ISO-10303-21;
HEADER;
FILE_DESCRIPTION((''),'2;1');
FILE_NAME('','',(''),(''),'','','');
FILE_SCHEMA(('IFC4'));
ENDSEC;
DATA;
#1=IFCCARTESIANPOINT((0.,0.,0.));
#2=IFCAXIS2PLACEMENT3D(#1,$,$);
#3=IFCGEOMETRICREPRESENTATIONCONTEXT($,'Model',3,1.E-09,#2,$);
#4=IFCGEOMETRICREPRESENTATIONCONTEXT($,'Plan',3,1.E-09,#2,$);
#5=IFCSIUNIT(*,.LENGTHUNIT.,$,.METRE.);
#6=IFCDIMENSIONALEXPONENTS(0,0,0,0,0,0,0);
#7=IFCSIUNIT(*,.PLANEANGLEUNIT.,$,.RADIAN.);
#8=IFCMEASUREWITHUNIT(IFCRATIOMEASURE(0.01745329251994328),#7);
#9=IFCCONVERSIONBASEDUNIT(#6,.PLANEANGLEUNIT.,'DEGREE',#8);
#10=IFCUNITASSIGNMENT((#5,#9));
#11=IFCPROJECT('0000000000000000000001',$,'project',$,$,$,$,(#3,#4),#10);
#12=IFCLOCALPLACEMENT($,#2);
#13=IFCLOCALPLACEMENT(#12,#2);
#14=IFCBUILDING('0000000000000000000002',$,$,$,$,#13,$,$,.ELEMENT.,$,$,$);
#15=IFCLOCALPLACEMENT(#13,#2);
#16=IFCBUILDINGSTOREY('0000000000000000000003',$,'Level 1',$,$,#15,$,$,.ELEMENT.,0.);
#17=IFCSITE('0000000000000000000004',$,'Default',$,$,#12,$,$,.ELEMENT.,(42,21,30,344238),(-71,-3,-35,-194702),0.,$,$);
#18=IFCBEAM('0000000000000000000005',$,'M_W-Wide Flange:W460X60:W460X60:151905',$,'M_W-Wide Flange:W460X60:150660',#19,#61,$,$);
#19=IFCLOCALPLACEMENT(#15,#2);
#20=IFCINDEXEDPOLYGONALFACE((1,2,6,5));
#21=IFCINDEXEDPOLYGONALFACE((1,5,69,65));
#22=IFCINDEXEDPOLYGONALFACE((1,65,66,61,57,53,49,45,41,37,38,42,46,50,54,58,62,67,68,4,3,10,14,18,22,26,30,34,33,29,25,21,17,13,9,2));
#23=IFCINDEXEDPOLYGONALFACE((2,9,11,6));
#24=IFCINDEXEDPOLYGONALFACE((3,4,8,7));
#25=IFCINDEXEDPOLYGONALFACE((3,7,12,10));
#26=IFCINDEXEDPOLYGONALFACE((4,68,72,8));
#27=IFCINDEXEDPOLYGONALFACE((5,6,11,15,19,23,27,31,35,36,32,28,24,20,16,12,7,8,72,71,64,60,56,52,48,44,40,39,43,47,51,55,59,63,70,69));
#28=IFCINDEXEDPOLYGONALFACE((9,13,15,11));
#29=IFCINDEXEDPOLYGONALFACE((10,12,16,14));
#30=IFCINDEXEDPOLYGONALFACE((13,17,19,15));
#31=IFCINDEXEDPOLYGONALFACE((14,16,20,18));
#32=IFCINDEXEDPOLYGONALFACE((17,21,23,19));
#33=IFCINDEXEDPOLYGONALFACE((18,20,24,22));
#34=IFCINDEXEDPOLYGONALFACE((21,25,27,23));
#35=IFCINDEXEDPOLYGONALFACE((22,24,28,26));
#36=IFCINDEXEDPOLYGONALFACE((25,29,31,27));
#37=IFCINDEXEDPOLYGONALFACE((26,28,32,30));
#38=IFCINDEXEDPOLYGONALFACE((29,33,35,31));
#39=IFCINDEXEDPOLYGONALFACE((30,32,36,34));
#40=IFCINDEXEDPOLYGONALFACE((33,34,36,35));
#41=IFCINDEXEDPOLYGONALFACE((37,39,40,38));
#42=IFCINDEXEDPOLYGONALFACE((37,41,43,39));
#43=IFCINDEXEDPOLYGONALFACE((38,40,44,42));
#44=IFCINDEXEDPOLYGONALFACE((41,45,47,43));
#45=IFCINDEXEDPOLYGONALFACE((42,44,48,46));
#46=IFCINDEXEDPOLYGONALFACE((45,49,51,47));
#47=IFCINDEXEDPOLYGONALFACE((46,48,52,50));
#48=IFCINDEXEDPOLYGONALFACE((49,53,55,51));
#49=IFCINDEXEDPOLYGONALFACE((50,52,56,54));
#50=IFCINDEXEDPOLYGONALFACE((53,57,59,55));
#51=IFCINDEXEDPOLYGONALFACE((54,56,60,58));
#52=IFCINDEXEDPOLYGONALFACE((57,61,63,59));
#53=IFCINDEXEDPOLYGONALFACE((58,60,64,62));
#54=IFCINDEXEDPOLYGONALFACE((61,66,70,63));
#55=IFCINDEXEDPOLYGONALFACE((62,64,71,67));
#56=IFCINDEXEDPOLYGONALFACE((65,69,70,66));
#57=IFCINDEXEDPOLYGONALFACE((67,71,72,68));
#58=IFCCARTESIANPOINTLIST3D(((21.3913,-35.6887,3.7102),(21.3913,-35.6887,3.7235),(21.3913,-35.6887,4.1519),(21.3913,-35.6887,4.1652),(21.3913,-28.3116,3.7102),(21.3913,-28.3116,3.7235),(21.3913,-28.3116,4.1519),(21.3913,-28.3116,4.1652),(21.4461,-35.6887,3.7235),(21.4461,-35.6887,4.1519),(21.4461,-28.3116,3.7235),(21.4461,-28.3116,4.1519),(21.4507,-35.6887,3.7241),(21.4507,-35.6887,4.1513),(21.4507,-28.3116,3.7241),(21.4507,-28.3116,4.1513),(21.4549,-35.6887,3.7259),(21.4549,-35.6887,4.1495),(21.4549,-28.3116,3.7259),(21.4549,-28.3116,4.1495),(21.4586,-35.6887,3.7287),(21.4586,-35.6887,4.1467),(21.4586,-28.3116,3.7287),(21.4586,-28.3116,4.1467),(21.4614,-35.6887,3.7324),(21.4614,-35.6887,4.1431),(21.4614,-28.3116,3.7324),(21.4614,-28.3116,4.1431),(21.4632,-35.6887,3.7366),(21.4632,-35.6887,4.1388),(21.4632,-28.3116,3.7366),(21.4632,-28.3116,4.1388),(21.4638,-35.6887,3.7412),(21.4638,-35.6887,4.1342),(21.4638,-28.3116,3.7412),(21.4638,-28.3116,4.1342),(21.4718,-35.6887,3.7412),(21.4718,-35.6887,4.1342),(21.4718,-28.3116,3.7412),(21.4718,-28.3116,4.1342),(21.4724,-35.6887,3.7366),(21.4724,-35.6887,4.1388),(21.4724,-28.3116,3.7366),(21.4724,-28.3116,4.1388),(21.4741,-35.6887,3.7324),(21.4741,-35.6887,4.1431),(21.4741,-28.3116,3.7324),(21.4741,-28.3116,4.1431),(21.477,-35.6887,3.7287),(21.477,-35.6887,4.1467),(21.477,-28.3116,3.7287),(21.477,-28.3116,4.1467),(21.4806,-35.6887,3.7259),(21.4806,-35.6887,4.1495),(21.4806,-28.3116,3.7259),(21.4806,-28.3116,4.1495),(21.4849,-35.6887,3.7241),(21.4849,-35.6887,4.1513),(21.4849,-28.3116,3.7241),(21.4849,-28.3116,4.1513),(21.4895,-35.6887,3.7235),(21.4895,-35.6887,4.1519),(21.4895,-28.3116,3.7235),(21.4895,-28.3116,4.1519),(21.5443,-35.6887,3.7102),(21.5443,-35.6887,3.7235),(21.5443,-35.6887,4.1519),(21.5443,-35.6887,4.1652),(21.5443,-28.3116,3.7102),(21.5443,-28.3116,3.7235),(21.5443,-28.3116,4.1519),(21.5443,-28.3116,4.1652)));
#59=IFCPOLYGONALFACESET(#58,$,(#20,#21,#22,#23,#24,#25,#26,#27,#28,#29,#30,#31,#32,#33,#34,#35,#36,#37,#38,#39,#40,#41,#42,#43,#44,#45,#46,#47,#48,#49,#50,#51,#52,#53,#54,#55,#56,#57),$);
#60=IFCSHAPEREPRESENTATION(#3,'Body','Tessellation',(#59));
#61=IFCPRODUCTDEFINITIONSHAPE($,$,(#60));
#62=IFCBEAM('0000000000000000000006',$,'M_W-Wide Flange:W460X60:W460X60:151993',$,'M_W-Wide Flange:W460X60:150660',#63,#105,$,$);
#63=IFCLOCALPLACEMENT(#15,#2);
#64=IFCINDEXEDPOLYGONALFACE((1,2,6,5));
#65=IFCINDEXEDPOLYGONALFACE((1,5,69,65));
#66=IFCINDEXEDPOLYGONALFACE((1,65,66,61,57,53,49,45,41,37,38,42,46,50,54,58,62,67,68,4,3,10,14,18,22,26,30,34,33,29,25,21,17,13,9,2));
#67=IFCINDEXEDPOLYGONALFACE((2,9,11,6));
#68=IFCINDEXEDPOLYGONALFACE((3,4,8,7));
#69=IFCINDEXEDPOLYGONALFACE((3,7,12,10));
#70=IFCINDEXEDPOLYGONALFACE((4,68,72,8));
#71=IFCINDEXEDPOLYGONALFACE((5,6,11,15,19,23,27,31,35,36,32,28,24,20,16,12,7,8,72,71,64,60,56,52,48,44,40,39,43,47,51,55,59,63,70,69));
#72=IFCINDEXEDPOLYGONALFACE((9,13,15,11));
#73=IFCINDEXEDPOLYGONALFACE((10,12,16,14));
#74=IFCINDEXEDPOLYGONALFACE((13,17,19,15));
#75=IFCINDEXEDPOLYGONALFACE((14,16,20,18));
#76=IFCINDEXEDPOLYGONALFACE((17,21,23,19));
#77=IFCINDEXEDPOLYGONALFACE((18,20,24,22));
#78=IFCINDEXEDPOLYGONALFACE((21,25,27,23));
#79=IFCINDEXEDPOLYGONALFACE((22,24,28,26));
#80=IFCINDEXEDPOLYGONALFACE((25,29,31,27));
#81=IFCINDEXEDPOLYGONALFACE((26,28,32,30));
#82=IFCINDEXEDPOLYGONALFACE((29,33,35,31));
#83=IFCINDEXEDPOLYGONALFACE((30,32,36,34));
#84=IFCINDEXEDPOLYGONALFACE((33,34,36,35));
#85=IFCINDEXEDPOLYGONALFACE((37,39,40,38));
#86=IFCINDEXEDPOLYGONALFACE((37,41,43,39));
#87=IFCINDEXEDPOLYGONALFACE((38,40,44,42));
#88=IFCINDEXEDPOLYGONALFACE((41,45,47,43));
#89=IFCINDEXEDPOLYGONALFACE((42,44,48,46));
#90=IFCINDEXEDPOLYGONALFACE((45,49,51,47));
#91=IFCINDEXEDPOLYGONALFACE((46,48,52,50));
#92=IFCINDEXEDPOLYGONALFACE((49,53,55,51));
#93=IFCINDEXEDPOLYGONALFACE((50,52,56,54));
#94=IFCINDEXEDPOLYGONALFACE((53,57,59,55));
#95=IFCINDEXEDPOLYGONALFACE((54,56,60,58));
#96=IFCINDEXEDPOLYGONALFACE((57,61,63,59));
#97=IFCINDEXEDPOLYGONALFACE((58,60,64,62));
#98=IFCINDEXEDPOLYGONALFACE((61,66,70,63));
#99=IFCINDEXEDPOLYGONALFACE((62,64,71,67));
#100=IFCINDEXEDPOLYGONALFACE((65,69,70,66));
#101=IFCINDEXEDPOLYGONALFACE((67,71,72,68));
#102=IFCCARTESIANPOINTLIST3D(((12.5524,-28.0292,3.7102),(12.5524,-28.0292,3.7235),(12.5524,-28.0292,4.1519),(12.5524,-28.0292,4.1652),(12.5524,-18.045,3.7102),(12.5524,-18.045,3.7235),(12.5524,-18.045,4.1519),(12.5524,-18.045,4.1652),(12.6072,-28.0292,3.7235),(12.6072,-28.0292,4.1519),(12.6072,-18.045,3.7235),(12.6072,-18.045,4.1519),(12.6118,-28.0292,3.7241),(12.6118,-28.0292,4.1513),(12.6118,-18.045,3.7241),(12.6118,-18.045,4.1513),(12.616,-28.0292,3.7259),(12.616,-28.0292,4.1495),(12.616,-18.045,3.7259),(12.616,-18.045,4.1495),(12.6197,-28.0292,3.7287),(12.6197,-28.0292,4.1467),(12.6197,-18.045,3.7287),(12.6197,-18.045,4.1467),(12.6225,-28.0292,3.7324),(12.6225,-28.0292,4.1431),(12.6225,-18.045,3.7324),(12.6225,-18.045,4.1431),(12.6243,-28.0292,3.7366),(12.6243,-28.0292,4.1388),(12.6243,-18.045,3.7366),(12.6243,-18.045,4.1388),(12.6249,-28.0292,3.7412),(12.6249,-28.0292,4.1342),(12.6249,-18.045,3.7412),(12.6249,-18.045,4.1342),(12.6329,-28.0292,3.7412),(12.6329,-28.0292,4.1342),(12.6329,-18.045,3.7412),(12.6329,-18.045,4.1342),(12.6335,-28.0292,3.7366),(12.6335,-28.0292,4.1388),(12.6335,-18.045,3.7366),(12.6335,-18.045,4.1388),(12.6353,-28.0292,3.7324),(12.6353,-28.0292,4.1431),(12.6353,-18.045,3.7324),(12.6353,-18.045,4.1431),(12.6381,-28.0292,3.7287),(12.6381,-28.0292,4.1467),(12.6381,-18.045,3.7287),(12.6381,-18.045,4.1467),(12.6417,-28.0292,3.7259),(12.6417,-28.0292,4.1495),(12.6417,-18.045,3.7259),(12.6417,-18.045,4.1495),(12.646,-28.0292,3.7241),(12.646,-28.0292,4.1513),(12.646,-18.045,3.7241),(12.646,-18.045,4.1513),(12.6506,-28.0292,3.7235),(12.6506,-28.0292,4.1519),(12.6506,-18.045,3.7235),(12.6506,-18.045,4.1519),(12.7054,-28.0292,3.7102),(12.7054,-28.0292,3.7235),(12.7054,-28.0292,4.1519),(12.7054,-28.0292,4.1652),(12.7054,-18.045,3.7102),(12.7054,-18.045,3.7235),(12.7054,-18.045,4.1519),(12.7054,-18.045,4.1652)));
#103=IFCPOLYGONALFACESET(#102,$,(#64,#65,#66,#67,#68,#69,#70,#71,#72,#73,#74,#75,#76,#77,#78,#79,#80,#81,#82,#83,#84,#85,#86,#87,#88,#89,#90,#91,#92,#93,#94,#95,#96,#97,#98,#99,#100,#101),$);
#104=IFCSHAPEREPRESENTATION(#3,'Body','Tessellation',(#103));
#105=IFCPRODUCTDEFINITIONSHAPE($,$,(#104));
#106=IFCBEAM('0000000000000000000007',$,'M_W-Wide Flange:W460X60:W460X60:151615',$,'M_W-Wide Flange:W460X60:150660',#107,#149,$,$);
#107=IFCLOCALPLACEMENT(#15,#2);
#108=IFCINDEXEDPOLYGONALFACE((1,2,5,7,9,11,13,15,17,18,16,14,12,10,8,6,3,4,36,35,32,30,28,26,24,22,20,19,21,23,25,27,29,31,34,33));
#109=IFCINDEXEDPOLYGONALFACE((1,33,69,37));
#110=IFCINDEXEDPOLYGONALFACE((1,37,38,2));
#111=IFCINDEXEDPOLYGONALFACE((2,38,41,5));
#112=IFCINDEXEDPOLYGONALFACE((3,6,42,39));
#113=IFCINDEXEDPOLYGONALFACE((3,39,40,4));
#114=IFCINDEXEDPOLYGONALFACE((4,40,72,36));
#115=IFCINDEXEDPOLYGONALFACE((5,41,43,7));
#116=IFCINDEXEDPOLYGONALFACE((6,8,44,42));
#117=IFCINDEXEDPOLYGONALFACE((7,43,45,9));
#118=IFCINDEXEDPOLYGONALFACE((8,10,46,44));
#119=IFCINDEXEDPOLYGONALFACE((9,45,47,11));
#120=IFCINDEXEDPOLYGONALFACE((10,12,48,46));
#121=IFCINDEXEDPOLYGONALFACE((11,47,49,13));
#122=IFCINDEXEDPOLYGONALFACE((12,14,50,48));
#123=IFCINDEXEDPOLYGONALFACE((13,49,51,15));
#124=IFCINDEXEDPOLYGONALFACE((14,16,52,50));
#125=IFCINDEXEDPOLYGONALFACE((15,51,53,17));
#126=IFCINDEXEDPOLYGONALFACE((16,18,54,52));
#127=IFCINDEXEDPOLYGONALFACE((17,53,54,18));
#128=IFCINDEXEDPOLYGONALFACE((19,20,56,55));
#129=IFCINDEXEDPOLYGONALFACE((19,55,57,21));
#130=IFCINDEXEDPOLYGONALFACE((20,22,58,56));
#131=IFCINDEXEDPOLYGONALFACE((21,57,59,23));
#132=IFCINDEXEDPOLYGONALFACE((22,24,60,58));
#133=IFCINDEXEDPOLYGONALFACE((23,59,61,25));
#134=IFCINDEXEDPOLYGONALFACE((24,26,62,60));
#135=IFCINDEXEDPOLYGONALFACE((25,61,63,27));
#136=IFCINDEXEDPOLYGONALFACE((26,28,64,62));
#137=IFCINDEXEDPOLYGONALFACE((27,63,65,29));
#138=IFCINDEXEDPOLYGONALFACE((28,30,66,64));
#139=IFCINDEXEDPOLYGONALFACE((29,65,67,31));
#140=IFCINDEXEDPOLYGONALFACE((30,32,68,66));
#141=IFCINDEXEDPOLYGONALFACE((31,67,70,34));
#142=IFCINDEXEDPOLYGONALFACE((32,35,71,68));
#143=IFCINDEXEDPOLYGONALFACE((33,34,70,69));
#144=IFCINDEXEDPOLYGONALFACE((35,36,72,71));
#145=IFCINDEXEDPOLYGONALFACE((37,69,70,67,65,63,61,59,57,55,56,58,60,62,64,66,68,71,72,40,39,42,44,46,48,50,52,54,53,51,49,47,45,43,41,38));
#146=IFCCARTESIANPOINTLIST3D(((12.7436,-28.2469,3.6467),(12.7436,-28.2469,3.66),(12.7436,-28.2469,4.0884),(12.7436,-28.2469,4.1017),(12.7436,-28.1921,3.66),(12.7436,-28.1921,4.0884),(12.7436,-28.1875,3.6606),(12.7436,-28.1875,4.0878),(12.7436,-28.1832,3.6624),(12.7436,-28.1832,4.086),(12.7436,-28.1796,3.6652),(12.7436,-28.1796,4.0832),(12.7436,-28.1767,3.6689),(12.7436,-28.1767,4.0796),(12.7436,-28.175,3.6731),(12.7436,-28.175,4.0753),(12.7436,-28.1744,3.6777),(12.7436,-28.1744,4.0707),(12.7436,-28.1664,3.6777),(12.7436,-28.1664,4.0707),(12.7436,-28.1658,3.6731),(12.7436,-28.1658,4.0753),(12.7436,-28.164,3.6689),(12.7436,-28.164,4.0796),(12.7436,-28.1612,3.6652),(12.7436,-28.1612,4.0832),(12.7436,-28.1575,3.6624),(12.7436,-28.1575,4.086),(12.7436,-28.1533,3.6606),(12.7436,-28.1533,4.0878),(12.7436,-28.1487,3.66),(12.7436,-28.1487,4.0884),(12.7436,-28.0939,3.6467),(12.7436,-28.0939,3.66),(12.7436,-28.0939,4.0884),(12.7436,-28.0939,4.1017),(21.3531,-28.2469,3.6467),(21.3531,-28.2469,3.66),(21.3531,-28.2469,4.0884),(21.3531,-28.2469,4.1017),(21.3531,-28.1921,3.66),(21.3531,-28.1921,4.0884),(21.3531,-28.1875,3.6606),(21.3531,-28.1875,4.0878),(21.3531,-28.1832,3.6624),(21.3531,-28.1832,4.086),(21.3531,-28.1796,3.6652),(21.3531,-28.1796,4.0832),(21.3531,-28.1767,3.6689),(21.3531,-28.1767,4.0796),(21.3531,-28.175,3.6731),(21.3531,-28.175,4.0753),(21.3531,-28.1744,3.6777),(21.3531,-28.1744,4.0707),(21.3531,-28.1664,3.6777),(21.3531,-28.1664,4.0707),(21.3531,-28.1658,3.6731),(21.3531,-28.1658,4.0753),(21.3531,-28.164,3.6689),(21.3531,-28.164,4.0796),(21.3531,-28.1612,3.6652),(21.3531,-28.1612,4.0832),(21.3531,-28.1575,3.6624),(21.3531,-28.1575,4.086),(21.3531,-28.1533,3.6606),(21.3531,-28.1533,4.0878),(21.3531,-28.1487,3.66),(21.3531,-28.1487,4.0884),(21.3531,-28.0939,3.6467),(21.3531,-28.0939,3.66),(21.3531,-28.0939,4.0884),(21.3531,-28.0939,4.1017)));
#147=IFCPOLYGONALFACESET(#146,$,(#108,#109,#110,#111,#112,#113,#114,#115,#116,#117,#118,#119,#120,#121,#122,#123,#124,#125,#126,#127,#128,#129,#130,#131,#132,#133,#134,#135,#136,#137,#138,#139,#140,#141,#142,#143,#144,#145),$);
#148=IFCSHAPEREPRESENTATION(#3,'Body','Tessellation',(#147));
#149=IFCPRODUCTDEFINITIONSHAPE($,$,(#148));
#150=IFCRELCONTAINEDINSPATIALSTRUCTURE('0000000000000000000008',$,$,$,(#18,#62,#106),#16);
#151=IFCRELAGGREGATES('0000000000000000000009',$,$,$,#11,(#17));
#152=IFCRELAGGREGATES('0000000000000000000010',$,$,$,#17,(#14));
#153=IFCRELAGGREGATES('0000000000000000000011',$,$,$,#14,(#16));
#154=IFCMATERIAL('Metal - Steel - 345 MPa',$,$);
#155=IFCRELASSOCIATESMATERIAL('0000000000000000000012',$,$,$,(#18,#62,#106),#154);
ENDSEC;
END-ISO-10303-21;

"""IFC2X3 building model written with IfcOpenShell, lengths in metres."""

from ifc_helpers import new_model, entity, si_unit, converted_unit, frame, frame_2d, origin, place, context, project, spatial, polyline, circle_curve, parameter, trimmed, segment, composite_curve, outline, extrude, material, element, save


model = new_model("IFC2X3")

# Units and contexts
model_context = context("Model", 3, precision=1e-09, world=origin())
plan_context = context("Plan", 3, precision=1e-09, world=origin())
ifc_project = project(units=[si_unit("LENGTHUNIT", "METRE"), converted_unit("PLANEANGLEUNIT", "DEGREE", entity("IfcRatioMeasure", 0.01745329251994328), si_unit("PLANEANGLEUNIT", "RADIAN"), dimensions=[0, 0, 0, 0, 0, 0, 0])], contexts=[model_context, plan_context])

# Site, building, storey
site_placement = place(None, origin())
site = spatial("IfcSite", under=ifc_project, at=site_placement, Name="Default", CompositionType="ELEMENT", RefLatitude=(42, 21, 30, 344238), RefLongitude=(-71, -3, -35, -194702), RefElevation=0.0)
building_placement = place(site_placement, origin())
building = spatial("IfcBuilding", under=site, at=building_placement, CompositionType="ELEMENT")
storey_placement = place(building_placement, origin())
storey = spatial("IfcBuildingStorey", under=building, at=storey_placement, Name="Level 1", CompositionType="ELEMENT", Elevation=0.0)

# Beams
ifc_material_1 = material(Name="Metal - Steel - 345 MPa")
beam_1_placement = place(storey_placement, frame((21.4678, -35.8299, 4.2672)))
element("IfcBeam", 1, at=beam_1_placement, inside=storey, material=ifc_material_1, Name="M_W-Wide Flange:W460X60:W460X60:151905", ObjectType="M_W-Wide Flange:W460X60:150660", context=model_context, shape_type="SweptSolid", body=[
    extrude(outline(composite_curve([segment(polyline([(-0.0765, -0.2142), (-0.0765, -0.2275)]), True, "CONTINUOUS"), segment(polyline([(-0.0765, -0.2275), (0.0765, -0.2275)]), True, "CONTINUOUS"), segment(polyline([(0.0765, -0.2275), (0.0765, -0.2142)]), True, "CONTINUOUS"), segment(polyline([(0.0765, -0.2142), (0.0217, -0.2142)]), True, "CONTINUOUS"), segment(trimmed(circle_curve(frame_2d((0.0217, -0.1965), x_axis=(0.0, -1.0)), 0.0177), [parameter(270.0)], [parameter(360.0)], True, "PARAMETER"), False, "CONTINUOUS"), segment(polyline([(0.004, -0.1965), (0.004, 0.1965)]), True, "CONTINUOUS"), segment(trimmed(circle_curve(frame_2d((0.0217, 0.1965), x_axis=(-1.0, 0.0)), 0.0177), [parameter(270.0)], [parameter(360.0)], True, "PARAMETER"), False, "CONTINUOUS"), segment(polyline([(0.0217, 0.2142), (0.0765, 0.2142)]), True, "CONTINUOUS"), segment(polyline([(0.0765, 0.2142), (0.0765, 0.2275)]), True, "CONTINUOUS"), segment(polyline([(0.0765, 0.2275), (-0.0765, 0.2275)]), True, "CONTINUOUS"), segment(polyline([(-0.0765, 0.2275), (-0.0765, 0.2142)]), True, "CONTINUOUS"), segment(polyline([(-0.0765, 0.2142), (-0.0217, 0.2142)]), True, "CONTINUOUS"), segment(trimmed(circle_curve(frame_2d((-0.0217, 0.1965), x_axis=(0.0, 1.0)), 0.0177), [parameter(270.0)], [parameter(360.0)], True, "PARAMETER"), False, "CONTINUOUS"), segment(polyline([(-0.004, 0.1965), (-0.004, -0.1965)]), True, "CONTINUOUS"), segment(trimmed(circle_curve(frame_2d((-0.0217, -0.1965), x_axis=(1.0, 0.0)), 0.0177), [parameter(270.0)], [parameter(0.0)], True, "PARAMETER"), False, "CONTINUOUS"), segment(polyline([(-0.0217, -0.2142), (-0.0765, -0.2142)]), True, "CONTINUOUS")], self_intersect=False)), frame((0.0, 0.1412, -0.3295), z_axis=(0.0, -1.0, 0.0), x_axis=(1.0, 0.0, 0.0)), (0.0, 0.0, -1.0), 7.3771),
])
beam_2_placement = place(storey_placement, frame((12.6289, -17.9038, 4.2672), z_axis=(0.0, 0.0, 1.0), x_axis=(-1.0, 0.0, 0.0)))
element("IfcBeam", 2, at=beam_2_placement, inside=storey, material=ifc_material_1, Name="M_W-Wide Flange:W460X60:W460X60:151993", ObjectType="M_W-Wide Flange:W460X60:150660", context=model_context, shape_type="SweptSolid", body=[
    extrude(outline(composite_curve([segment(polyline([(0.2142, -0.0765), (0.2275, -0.0765)]), True, "CONTINUOUS"), segment(polyline([(0.2275, -0.0765), (0.2275, 0.0765)]), True, "CONTINUOUS"), segment(polyline([(0.2275, 0.0765), (0.2142, 0.0765)]), True, "CONTINUOUS"), segment(polyline([(0.2142, 0.0765), (0.2142, 0.0217)]), True, "CONTINUOUS"), segment(trimmed(circle_curve(frame_2d((0.1965, 0.0217), x_axis=(1.0, 0.0)), 0.0177), [parameter(270.0)], [parameter(360.0)], True, "PARAMETER"), False, "CONTINUOUS"), segment(polyline([(0.1965, 0.004), (-0.1965, 0.004)]), True, "CONTINUOUS"), segment(trimmed(circle_curve(frame_2d((-0.1965, 0.0217), x_axis=(0.0, -1.0)), 0.0177), [parameter(270.0)], [parameter(360.0)], True, "PARAMETER"), False, "CONTINUOUS"), segment(polyline([(-0.2142, 0.0217), (-0.2142, 0.0765)]), True, "CONTINUOUS"), segment(polyline([(-0.2142, 0.0765), (-0.2275, 0.0765)]), True, "CONTINUOUS"), segment(polyline([(-0.2275, 0.0765), (-0.2275, -0.0765)]), True, "CONTINUOUS"), segment(polyline([(-0.2275, -0.0765), (-0.2142, -0.0765)]), True, "CONTINUOUS"), segment(polyline([(-0.2142, -0.0765), (-0.2142, -0.0217)]), True, "CONTINUOUS"), segment(trimmed(circle_curve(frame_2d((-0.1965, -0.0217), x_axis=(-1.0, 0.0)), 0.0177), [parameter(270.0)], [parameter(360.0)], True, "PARAMETER"), False, "CONTINUOUS"), segment(polyline([(-0.1965, -0.004), (0.1965, -0.004)]), True, "CONTINUOUS"), segment(trimmed(circle_curve(frame_2d((0.1965, -0.0217), x_axis=(0.0, 1.0)), 0.0177), [parameter(270.0)], [parameter(0.0)], True, "PARAMETER"), False, "CONTINUOUS"), segment(polyline([(0.2142, -0.0217), (0.2142, -0.0765)]), True, "CONTINUOUS")], self_intersect=False)), frame((0.0, 10.1253, -0.3295), z_axis=(0.0, -1.0, 0.0), x_axis=(0.0, 0.0, -1.0)), (0.0, 0.0, 1.0), 9.9841),
])
beam_3_placement = place(storey_placement, frame((12.6289, -28.1704, 4.2672), z_axis=(0.0, 0.0, 1.0), x_axis=(0.0, -1.0, 0.0)))
element("IfcBeam", 3, at=beam_3_placement, inside=storey, material=ifc_material_1, Name="M_W-Wide Flange:W460X60:W460X60:151615", ObjectType="M_W-Wide Flange:W460X60:150660", context=model_context, shape_type="SweptSolid", body=[
    extrude(outline(composite_curve([segment(polyline([(-0.0765, -0.2142), (-0.0765, -0.2275)]), True, "CONTINUOUS"), segment(polyline([(-0.0765, -0.2275), (0.0765, -0.2275)]), True, "CONTINUOUS"), segment(polyline([(0.0765, -0.2275), (0.0765, -0.2142)]), True, "CONTINUOUS"), segment(polyline([(0.0765, -0.2142), (0.0217, -0.2142)]), True, "CONTINUOUS"), segment(trimmed(circle_curve(frame_2d((0.0217, -0.1965), x_axis=(0.0, -1.0)), 0.0177), [parameter(270.0)], [parameter(360.0)], True, "PARAMETER"), False, "CONTINUOUS"), segment(polyline([(0.004, -0.1965), (0.004, 0.1965)]), True, "CONTINUOUS"), segment(trimmed(circle_curve(frame_2d((0.0217, 0.1965), x_axis=(-1.0, 0.0)), 0.0177), [parameter(270.0)], [parameter(360.0)], True, "PARAMETER"), False, "CONTINUOUS"), segment(polyline([(0.0217, 0.2142), (0.0765, 0.2142)]), True, "CONTINUOUS"), segment(polyline([(0.0765, 0.2142), (0.0765, 0.2275)]), True, "CONTINUOUS"), segment(polyline([(0.0765, 0.2275), (-0.0765, 0.2275)]), True, "CONTINUOUS"), segment(polyline([(-0.0765, 0.2275), (-0.0765, 0.2142)]), True, "CONTINUOUS"), segment(polyline([(-0.0765, 0.2142), (-0.0217, 0.2142)]), True, "CONTINUOUS"), segment(trimmed(circle_curve(frame_2d((-0.0217, 0.1965), x_axis=(0.0, 1.0)), 0.0177), [parameter(270.0)], [parameter(360.0)], True, "PARAMETER"), False, "CONTINUOUS"), segment(polyline([(-0.004, 0.1965), (-0.004, -0.1965)]), True, "CONTINUOUS"), segment(trimmed(circle_curve(frame_2d((-0.0217, -0.1965), x_axis=(1.0, 0.0)), 0.0177), [parameter(270.0)], [parameter(0.0)], True, "PARAMETER"), False, "CONTINUOUS"), segment(polyline([(-0.0217, -0.2142), (-0.0765, -0.2142)]), True, "CONTINUOUS")], self_intersect=False)), frame((0.0, 0.1147, -0.393), z_axis=(0.0, -1.0, 0.0), x_axis=(1.0, 0.0, 0.0)), (0.0, 0.0, -1.0), 8.6095),
])

save(model, "model.ifc")
